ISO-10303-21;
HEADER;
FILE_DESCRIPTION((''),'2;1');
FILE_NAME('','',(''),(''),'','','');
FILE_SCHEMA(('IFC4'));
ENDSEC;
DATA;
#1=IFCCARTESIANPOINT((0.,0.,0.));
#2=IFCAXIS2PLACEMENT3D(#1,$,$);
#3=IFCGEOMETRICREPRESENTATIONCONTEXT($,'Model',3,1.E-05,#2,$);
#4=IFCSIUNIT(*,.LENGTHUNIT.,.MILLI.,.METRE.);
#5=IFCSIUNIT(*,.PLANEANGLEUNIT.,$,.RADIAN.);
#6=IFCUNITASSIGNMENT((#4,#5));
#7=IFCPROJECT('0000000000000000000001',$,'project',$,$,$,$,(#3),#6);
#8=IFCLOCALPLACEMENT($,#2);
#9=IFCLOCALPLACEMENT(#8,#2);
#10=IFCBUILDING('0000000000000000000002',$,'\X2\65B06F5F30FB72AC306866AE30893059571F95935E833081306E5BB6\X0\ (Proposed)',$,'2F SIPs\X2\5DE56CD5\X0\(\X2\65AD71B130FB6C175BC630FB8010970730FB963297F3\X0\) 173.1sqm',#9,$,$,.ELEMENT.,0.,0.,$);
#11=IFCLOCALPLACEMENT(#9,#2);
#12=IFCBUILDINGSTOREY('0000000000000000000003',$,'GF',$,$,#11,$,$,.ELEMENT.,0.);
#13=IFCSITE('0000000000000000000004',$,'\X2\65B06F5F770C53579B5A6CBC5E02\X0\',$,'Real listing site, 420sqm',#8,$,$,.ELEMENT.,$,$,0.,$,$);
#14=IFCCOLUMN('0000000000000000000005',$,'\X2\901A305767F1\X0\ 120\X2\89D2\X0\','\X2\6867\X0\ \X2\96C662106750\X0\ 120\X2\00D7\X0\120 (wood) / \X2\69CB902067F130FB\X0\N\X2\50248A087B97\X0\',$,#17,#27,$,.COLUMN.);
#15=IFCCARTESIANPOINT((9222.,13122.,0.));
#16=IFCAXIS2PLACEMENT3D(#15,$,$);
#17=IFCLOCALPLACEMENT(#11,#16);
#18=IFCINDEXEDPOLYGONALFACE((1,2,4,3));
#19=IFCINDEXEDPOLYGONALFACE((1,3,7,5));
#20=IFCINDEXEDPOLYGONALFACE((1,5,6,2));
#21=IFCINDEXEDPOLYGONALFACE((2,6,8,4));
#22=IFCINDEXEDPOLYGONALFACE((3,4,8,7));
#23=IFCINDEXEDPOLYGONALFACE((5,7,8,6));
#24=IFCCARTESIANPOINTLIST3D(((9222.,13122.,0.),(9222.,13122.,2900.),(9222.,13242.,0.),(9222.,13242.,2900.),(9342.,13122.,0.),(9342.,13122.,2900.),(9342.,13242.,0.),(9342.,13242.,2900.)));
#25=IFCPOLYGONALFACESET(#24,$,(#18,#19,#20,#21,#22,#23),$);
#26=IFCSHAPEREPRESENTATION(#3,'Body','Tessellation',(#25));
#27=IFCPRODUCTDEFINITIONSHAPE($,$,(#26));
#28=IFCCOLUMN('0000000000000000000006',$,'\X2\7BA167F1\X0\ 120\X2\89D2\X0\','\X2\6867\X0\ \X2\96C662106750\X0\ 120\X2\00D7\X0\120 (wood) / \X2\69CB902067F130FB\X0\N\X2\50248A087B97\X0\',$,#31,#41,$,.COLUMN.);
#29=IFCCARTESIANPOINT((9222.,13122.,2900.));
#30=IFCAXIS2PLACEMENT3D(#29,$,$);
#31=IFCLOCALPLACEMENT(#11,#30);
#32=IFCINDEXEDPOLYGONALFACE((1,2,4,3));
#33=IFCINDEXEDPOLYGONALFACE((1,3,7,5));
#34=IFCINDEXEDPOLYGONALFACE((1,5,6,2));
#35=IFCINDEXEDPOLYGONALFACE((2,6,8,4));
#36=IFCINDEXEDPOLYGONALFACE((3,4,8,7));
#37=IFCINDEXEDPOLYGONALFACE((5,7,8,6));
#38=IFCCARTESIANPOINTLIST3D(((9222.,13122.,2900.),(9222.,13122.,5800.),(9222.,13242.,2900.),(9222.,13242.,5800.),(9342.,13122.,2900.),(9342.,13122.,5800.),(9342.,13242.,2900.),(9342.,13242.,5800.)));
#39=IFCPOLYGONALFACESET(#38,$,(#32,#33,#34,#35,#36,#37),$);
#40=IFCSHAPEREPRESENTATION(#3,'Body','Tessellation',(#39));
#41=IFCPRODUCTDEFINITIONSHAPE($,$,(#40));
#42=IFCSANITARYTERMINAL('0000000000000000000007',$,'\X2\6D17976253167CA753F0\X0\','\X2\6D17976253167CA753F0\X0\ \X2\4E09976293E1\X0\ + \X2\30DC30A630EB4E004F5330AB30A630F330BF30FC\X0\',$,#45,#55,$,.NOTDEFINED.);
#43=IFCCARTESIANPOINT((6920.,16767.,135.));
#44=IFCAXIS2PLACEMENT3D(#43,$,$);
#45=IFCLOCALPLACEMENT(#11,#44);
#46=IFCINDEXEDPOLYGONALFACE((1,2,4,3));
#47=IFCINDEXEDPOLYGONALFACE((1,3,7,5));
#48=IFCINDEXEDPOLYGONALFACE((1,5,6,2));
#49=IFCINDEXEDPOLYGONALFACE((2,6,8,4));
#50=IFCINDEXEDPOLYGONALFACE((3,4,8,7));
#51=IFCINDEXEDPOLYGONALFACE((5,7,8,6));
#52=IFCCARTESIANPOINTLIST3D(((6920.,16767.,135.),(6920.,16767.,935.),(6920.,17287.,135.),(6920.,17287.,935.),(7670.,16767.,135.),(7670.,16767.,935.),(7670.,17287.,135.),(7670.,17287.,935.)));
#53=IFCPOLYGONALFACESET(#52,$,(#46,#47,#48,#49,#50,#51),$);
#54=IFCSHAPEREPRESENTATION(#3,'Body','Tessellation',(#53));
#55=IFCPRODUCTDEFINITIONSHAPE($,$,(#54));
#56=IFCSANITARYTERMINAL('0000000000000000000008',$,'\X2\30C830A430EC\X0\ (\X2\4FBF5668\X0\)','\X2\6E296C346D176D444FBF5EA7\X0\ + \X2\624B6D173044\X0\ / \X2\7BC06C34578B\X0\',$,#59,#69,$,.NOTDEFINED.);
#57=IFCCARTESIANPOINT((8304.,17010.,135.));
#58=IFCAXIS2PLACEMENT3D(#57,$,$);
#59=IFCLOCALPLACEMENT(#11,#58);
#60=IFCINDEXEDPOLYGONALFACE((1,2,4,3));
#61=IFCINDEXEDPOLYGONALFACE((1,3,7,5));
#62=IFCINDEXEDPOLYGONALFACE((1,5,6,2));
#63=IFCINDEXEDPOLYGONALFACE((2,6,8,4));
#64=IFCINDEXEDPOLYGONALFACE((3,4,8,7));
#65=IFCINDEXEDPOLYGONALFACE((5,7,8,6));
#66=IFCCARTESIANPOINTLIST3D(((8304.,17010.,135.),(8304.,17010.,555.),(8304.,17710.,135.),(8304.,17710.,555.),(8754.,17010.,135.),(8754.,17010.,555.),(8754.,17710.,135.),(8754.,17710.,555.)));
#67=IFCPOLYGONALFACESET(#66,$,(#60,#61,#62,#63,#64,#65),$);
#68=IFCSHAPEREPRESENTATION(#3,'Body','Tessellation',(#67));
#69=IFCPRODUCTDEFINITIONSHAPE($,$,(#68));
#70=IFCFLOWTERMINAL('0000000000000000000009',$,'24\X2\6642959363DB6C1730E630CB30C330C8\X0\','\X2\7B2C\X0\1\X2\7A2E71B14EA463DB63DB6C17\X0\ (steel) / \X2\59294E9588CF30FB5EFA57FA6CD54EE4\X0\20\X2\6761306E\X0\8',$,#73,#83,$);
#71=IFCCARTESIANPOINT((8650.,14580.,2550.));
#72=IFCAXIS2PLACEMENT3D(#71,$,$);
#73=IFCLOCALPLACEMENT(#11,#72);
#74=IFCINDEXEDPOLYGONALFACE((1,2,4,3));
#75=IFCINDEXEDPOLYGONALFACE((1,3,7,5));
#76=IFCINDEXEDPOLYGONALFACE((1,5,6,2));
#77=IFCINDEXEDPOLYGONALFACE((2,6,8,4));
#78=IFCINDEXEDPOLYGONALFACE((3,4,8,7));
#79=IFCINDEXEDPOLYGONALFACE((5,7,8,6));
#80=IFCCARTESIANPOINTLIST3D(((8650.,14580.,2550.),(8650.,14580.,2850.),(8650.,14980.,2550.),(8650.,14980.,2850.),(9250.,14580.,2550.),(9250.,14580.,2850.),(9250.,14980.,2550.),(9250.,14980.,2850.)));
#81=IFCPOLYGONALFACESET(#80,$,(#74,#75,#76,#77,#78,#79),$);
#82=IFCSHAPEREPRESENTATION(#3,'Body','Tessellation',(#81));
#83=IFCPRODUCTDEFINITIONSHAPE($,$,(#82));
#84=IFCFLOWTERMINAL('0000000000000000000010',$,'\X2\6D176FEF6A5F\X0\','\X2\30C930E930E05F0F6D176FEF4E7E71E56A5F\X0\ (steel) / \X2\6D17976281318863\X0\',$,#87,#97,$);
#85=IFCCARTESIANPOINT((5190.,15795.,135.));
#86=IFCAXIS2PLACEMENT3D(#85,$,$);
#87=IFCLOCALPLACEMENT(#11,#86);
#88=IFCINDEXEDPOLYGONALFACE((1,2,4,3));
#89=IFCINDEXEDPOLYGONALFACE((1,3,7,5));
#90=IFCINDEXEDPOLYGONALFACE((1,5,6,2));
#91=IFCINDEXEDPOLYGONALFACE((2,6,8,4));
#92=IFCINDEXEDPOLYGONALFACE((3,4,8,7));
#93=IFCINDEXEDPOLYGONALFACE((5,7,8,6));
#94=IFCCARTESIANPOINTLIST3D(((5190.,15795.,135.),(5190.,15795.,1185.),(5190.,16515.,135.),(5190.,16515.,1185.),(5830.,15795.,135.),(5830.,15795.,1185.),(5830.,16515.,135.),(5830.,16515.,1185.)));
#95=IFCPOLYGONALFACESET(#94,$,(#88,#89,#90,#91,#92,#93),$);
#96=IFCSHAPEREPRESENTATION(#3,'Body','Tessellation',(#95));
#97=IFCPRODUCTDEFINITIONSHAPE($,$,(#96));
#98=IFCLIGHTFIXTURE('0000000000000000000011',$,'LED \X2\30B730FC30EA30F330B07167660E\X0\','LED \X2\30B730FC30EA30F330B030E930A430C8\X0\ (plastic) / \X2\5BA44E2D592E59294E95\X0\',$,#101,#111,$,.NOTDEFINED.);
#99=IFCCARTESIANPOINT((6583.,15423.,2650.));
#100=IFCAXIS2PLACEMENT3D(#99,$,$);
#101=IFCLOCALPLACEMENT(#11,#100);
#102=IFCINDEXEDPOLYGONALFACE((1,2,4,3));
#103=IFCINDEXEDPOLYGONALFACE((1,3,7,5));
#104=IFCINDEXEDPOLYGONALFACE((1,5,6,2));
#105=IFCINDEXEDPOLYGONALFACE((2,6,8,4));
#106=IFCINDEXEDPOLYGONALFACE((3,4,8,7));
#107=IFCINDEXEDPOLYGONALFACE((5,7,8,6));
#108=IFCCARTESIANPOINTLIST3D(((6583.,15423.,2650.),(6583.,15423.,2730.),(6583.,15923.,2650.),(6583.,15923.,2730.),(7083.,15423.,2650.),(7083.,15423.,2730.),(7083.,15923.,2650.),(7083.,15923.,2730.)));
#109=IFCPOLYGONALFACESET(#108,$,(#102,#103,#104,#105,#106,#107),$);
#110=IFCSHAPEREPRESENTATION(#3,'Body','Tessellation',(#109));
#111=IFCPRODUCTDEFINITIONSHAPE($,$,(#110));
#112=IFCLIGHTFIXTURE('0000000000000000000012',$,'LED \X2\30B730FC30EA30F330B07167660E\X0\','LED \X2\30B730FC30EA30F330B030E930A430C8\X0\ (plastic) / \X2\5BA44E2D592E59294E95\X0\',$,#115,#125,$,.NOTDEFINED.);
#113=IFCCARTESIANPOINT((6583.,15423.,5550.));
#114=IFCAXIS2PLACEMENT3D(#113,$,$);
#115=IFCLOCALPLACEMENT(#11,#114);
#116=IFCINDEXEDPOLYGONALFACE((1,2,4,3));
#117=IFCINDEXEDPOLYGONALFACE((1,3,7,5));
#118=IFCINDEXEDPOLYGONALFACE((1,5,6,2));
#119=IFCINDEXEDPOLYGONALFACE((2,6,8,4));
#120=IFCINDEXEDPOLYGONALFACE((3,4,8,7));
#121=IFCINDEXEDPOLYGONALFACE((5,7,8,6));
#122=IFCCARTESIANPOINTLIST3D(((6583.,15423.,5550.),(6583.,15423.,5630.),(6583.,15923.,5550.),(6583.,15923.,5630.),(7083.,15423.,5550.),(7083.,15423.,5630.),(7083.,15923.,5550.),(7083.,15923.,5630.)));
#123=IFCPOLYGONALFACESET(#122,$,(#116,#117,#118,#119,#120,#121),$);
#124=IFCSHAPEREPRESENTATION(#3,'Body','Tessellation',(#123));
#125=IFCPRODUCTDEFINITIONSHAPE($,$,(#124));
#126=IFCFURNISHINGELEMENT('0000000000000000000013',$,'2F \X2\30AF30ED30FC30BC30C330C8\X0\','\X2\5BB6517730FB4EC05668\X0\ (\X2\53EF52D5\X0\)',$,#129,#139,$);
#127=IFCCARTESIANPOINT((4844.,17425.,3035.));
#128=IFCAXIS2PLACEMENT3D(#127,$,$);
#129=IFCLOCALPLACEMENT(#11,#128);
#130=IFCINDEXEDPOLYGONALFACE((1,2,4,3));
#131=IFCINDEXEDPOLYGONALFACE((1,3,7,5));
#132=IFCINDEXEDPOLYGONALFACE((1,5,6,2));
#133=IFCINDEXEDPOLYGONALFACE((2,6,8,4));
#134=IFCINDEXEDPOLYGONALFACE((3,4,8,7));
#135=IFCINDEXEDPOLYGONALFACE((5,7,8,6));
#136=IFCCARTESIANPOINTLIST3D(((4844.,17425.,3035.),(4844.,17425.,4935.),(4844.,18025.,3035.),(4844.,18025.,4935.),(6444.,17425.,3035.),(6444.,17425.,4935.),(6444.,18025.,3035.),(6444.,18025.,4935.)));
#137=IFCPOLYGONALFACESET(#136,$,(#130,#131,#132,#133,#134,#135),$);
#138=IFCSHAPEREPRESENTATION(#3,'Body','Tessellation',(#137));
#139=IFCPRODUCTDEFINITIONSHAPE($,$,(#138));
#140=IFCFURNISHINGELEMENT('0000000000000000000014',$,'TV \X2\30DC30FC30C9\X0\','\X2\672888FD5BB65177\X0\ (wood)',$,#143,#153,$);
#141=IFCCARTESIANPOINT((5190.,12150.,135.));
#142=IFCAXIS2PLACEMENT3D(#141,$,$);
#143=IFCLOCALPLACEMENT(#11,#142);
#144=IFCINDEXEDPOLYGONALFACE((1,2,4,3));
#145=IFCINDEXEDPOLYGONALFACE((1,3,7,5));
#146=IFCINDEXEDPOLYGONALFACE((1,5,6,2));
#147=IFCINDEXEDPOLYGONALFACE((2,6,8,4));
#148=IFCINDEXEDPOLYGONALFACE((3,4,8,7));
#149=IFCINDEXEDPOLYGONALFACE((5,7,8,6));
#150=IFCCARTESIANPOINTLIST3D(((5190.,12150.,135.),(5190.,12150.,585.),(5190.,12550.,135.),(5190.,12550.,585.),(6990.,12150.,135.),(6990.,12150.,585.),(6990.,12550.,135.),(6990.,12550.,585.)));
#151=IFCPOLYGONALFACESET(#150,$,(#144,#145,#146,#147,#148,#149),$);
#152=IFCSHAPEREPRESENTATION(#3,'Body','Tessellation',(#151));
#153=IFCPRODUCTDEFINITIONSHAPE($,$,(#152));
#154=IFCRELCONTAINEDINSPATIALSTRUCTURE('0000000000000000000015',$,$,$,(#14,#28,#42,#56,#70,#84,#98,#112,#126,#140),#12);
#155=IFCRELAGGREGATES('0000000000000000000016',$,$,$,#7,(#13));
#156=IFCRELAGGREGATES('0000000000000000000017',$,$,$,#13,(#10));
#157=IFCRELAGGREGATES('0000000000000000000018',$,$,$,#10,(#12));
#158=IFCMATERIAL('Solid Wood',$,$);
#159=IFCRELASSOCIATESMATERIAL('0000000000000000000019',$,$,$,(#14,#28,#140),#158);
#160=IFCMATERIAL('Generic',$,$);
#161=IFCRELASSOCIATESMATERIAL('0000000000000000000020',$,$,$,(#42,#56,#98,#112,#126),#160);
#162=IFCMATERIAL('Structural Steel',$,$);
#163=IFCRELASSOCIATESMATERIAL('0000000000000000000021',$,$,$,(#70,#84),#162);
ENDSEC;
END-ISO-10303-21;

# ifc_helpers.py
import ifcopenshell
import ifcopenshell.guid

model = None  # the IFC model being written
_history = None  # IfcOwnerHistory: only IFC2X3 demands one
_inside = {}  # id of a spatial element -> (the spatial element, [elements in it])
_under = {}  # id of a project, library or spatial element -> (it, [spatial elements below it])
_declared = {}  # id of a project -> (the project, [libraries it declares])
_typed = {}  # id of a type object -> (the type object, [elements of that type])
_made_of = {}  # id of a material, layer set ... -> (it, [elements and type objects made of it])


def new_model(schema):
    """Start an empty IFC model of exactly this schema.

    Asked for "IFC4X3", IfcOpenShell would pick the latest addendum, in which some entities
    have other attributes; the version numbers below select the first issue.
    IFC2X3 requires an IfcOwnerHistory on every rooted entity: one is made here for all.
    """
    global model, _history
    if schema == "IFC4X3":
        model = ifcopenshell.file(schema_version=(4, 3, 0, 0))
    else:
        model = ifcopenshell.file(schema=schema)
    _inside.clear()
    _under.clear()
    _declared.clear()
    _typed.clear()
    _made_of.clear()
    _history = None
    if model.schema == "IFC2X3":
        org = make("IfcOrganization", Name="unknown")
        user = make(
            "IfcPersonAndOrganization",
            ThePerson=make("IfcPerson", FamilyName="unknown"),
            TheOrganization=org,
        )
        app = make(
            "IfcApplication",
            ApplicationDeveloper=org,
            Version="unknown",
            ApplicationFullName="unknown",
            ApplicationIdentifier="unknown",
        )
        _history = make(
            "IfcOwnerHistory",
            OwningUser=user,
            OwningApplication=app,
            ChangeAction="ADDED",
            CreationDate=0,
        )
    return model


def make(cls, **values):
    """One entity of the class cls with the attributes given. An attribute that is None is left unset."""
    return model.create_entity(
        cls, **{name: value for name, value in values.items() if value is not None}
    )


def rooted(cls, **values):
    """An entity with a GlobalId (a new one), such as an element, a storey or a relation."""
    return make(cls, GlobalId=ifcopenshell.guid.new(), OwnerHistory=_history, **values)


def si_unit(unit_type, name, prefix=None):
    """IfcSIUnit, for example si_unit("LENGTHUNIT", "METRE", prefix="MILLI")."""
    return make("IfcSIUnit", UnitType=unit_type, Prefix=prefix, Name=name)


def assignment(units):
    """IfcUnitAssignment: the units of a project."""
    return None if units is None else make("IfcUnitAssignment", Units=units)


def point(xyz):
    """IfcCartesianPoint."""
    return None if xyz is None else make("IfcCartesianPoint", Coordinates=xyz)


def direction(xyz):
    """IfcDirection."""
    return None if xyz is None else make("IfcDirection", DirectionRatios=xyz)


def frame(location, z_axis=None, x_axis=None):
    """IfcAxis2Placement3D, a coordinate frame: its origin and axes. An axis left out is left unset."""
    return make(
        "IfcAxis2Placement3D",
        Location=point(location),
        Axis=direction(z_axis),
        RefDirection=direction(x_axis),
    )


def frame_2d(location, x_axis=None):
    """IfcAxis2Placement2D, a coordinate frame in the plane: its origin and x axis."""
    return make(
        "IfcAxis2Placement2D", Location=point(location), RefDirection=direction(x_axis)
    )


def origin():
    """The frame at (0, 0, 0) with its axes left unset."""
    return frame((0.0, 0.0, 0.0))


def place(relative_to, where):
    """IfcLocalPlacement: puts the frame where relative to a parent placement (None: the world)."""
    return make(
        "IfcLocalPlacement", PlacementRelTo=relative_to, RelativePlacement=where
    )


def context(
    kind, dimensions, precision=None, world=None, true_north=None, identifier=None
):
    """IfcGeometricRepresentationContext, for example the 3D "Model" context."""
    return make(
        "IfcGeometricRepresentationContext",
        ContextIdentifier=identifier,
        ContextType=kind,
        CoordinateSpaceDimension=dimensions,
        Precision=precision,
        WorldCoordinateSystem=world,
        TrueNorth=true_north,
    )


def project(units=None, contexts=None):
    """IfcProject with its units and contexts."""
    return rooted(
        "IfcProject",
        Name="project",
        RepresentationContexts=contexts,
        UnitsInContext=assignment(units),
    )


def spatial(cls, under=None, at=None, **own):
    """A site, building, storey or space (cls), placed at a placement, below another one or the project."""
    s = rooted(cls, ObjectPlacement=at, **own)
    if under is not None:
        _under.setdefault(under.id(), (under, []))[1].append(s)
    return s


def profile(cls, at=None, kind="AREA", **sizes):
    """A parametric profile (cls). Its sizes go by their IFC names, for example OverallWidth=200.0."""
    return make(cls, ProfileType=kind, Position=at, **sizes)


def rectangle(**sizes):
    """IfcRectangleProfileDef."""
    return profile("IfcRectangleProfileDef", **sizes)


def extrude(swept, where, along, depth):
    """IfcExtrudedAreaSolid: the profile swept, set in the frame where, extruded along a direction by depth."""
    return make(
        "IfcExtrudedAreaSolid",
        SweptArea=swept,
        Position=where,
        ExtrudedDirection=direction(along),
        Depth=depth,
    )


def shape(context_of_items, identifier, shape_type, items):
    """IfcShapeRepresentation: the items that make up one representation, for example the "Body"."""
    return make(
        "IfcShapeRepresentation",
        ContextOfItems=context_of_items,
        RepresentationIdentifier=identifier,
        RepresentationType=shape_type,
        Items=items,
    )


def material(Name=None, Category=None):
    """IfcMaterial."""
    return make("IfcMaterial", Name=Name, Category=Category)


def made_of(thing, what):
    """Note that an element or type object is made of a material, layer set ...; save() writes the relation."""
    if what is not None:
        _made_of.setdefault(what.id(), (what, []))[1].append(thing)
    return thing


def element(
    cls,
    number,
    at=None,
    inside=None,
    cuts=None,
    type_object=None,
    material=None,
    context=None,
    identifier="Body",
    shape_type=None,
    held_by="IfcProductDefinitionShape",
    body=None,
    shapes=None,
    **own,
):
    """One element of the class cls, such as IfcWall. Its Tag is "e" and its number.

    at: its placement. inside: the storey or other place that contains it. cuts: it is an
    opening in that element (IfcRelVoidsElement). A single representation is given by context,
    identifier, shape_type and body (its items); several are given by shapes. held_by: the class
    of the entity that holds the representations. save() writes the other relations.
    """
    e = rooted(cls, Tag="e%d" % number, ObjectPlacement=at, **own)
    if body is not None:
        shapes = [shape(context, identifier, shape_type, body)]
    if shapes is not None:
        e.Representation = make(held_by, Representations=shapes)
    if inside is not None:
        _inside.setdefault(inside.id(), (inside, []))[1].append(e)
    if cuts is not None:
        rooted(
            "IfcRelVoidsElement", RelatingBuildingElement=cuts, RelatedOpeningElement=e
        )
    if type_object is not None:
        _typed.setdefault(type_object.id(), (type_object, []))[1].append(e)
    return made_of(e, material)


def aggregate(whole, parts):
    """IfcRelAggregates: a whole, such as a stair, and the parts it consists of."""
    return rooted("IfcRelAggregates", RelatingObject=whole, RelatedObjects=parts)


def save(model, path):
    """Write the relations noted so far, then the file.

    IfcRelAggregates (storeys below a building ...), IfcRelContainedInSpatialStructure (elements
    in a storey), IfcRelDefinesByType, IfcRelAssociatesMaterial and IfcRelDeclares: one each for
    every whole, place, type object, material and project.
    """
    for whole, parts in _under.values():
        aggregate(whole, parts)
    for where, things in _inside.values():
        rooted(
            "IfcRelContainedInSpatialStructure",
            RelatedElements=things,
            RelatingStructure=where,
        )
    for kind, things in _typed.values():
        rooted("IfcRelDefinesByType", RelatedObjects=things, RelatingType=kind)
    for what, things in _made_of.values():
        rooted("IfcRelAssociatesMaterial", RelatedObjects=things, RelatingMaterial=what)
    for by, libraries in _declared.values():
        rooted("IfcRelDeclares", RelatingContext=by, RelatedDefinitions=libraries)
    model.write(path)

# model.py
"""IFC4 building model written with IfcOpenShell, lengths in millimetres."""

from ifc_helpers import new_model, si_unit, frame, frame_2d, origin, place, context, project, spatial, rectangle, extrude, material, element, save


model = new_model("IFC4")

# Units and contexts
model_context = context("Model", 3, precision=1e-05, world=origin())
ifc_project = project(units=[si_unit("LENGTHUNIT", "METRE", prefix="MILLI"), si_unit("PLANEANGLEUNIT", "RADIAN")], contexts=[model_context])

# Site, building, storey
site_placement = place(None, origin())
site = spatial("IfcSite", under=ifc_project, at=site_placement, Name="新潟県南魚沼市", ObjectType="Real listing site, 420sqm", CompositionType="ELEMENT", RefElevation=0.0)
building_placement = place(site_placement, origin())
building = spatial("IfcBuilding", under=site, at=building_placement, Name="新潟・犬と暮らす土間広めの家 (Proposed)", ObjectType="2F SIPs工法(断熱・気密・耐震・防音) 173.1sqm", CompositionType="ELEMENT", ElevationOfRefHeight=0.0, ElevationOfTerrain=0.0)
storey_placement = place(building_placement, origin())
storey = spatial("IfcBuildingStorey", under=building, at=storey_placement, Name="GF", CompositionType="ELEMENT", Elevation=0.0)

# Columns
ifc_material_1 = material(Name="Solid Wood")
column_1_placement = place(storey_placement, frame((9222.0, 13122.0, 0.0)))
element("IfcColumn", 1, at=column_1_placement, inside=storey, material=ifc_material_1, Name="通し柱 120角", Description="桧 集成材 120×120 (wood) / 構造柱・N値計算", PredefinedType="COLUMN", context=model_context, shape_type="SweptSolid", body=[
    extrude(rectangle(XDim=120.0, YDim=120.0, at=frame_2d((60.0, 60.0))), frame((9222.0, 13122.0, 0.0)), (0.0, 0.0, 1.0), 2900.0),
])
column_2_placement = place(storey_placement, frame((9222.0, 13122.0, 2900.0)))
element("IfcColumn", 2, at=column_2_placement, inside=storey, material=ifc_material_1, Name="管柱 120角", Description="桧 集成材 120×120 (wood) / 構造柱・N値計算", PredefinedType="COLUMN", context=model_context, shape_type="SweptSolid", body=[
    extrude(rectangle(XDim=120.0, YDim=120.0, at=frame_2d((60.0, 60.0))), frame((9222.0, 13122.0, 2900.0)), (0.0, 0.0, 1.0), 2900.0),
])

# Sanitary terminals
ifc_material_2 = material(Name="Generic")
sanitary_terminal_1_placement = place(storey_placement, frame((6920.0, 16767.0, 135.0)))
element("IfcSanitaryTerminal", 3, at=sanitary_terminal_1_placement, inside=storey, material=ifc_material_2, Name="洗面化粧台", Description="洗面化粧台 三面鏡 + ボウル一体カウンター", PredefinedType="NOTDEFINED", context=model_context, shape_type="SweptSolid", body=[
    extrude(rectangle(XDim=750.0, YDim=520.0, at=frame_2d((375.0, 260.0))), frame((6920.0, 16767.0, 135.0)), (0.0, 0.0, 1.0), 800.0),
])
sanitary_terminal_2_placement = place(storey_placement, frame((8304.0, 17010.0, 135.0)))
element("IfcSanitaryTerminal", 4, at=sanitary_terminal_2_placement, inside=storey, material=ifc_material_2, Name="トイレ (便器)", Description="温水洗浄便座 + 手洗い / 節水型", PredefinedType="NOTDEFINED", context=model_context, shape_type="SweptSolid", body=[
    extrude(rectangle(XDim=450.0, YDim=700.0, at=frame_2d((225.0, 350.0))), frame((8304.0, 17010.0, 135.0)), (0.0, 0.0, 1.0), 420.0),
])

# Flow terminals
ifc_material_3 = material(Name="Structural Steel")
flow_terminal_1_placement = place(storey_placement, frame((8650.0, 14580.0, 2550.0)))
element("IfcFlowTerminal", 5, at=flow_terminal_1_placement, inside=storey, material=ifc_material_3, Name="24時間換気ユニット", Description="第1種熱交換換気 (steel) / 天井裏・建基法令20条の8", context=model_context, shape_type="SweptSolid", body=[
    extrude(rectangle(XDim=600.0, YDim=400.0, at=frame_2d((300.0, 200.0))), frame((8650.0, 14580.0, 2550.0)), (0.0, 0.0, 1.0), 300.0),
])
flow_terminal_2_placement = place(storey_placement, frame((5190.0, 15795.0, 135.0)))
element("IfcFlowTerminal", 6, at=flow_terminal_2_placement, inside=storey, material=ifc_material_3, Name="洗濯機", Description="ドラム式洗濯乾燥機 (steel) / 洗面脱衣", context=model_context, shape_type="SweptSolid", body=[
    extrude(rectangle(XDim=640.0, YDim=720.0, at=frame_2d((320.0, 360.0))), frame((5190.0, 15795.0, 135.0)), (0.0, 0.0, 1.0), 1050.0),
])

# Light fixtures
light_fixture_1_placement = place(storey_placement, frame((6583.0, 15423.0, 2650.0)))
element("IfcLightFixture", 7, at=light_fixture_1_placement, inside=storey, material=ifc_material_2, Name="LED シーリング照明", Description="LED シーリングライト (plastic) / 室中央天井", PredefinedType="NOTDEFINED", context=model_context, shape_type="SweptSolid", body=[
    extrude(rectangle(XDim=500.0, YDim=500.0, at=frame_2d((250.0, 250.0))), frame((6583.0, 15423.0, 2650.0)), (0.0, 0.0, 1.0), 80.0),
])
light_fixture_2_placement = place(storey_placement, frame((6583.0, 15423.0, 5550.0)))
element("IfcLightFixture", 8, at=light_fixture_2_placement, inside=storey, material=ifc_material_2, Name="LED シーリング照明", Description="LED シーリングライト (plastic) / 室中央天井", PredefinedType="NOTDEFINED", context=model_context, shape_type="SweptSolid", body=[
    extrude(rectangle(XDim=500.0, YDim=500.0, at=frame_2d((250.0, 250.0))), frame((6583.0, 15423.0, 5550.0)), (0.0, 0.0, 1.0), 80.0),
])

# Furnishing elements
furnishing_1_placement = place(storey_placement, frame((4844.0, 17425.0, 3035.0)))
element("IfcFurnishingElement", 9, at=furnishing_1_placement, inside=storey, material=ifc_material_2, Name="2F クローゼット", Description="家具・什器 (可動)", context=model_context, shape_type="SweptSolid", body=[
    extrude(rectangle(XDim=1600.0, YDim=600.0, at=frame_2d((800.0, 300.0))), frame((4844.0, 17425.0, 3035.0)), (0.0, 0.0, 1.0), 1900.0),
])
furnishing_2_placement = place(storey_placement, frame((5190.0, 12150.0, 135.0)))
element("IfcFurnishingElement", 10, at=furnishing_2_placement, inside=storey, material=ifc_material_1, Name="TV ボード", Description="木製家具 (wood)", context=model_context, shape_type="SweptSolid", body=[
    extrude(rectangle(XDim=1800.0, YDim=400.0, at=frame_2d((900.0, 200.0))), frame((5190.0, 12150.0, 135.0)), (0.0, 0.0, 1.0), 450.0),
])

save(model, "model.ifc")
